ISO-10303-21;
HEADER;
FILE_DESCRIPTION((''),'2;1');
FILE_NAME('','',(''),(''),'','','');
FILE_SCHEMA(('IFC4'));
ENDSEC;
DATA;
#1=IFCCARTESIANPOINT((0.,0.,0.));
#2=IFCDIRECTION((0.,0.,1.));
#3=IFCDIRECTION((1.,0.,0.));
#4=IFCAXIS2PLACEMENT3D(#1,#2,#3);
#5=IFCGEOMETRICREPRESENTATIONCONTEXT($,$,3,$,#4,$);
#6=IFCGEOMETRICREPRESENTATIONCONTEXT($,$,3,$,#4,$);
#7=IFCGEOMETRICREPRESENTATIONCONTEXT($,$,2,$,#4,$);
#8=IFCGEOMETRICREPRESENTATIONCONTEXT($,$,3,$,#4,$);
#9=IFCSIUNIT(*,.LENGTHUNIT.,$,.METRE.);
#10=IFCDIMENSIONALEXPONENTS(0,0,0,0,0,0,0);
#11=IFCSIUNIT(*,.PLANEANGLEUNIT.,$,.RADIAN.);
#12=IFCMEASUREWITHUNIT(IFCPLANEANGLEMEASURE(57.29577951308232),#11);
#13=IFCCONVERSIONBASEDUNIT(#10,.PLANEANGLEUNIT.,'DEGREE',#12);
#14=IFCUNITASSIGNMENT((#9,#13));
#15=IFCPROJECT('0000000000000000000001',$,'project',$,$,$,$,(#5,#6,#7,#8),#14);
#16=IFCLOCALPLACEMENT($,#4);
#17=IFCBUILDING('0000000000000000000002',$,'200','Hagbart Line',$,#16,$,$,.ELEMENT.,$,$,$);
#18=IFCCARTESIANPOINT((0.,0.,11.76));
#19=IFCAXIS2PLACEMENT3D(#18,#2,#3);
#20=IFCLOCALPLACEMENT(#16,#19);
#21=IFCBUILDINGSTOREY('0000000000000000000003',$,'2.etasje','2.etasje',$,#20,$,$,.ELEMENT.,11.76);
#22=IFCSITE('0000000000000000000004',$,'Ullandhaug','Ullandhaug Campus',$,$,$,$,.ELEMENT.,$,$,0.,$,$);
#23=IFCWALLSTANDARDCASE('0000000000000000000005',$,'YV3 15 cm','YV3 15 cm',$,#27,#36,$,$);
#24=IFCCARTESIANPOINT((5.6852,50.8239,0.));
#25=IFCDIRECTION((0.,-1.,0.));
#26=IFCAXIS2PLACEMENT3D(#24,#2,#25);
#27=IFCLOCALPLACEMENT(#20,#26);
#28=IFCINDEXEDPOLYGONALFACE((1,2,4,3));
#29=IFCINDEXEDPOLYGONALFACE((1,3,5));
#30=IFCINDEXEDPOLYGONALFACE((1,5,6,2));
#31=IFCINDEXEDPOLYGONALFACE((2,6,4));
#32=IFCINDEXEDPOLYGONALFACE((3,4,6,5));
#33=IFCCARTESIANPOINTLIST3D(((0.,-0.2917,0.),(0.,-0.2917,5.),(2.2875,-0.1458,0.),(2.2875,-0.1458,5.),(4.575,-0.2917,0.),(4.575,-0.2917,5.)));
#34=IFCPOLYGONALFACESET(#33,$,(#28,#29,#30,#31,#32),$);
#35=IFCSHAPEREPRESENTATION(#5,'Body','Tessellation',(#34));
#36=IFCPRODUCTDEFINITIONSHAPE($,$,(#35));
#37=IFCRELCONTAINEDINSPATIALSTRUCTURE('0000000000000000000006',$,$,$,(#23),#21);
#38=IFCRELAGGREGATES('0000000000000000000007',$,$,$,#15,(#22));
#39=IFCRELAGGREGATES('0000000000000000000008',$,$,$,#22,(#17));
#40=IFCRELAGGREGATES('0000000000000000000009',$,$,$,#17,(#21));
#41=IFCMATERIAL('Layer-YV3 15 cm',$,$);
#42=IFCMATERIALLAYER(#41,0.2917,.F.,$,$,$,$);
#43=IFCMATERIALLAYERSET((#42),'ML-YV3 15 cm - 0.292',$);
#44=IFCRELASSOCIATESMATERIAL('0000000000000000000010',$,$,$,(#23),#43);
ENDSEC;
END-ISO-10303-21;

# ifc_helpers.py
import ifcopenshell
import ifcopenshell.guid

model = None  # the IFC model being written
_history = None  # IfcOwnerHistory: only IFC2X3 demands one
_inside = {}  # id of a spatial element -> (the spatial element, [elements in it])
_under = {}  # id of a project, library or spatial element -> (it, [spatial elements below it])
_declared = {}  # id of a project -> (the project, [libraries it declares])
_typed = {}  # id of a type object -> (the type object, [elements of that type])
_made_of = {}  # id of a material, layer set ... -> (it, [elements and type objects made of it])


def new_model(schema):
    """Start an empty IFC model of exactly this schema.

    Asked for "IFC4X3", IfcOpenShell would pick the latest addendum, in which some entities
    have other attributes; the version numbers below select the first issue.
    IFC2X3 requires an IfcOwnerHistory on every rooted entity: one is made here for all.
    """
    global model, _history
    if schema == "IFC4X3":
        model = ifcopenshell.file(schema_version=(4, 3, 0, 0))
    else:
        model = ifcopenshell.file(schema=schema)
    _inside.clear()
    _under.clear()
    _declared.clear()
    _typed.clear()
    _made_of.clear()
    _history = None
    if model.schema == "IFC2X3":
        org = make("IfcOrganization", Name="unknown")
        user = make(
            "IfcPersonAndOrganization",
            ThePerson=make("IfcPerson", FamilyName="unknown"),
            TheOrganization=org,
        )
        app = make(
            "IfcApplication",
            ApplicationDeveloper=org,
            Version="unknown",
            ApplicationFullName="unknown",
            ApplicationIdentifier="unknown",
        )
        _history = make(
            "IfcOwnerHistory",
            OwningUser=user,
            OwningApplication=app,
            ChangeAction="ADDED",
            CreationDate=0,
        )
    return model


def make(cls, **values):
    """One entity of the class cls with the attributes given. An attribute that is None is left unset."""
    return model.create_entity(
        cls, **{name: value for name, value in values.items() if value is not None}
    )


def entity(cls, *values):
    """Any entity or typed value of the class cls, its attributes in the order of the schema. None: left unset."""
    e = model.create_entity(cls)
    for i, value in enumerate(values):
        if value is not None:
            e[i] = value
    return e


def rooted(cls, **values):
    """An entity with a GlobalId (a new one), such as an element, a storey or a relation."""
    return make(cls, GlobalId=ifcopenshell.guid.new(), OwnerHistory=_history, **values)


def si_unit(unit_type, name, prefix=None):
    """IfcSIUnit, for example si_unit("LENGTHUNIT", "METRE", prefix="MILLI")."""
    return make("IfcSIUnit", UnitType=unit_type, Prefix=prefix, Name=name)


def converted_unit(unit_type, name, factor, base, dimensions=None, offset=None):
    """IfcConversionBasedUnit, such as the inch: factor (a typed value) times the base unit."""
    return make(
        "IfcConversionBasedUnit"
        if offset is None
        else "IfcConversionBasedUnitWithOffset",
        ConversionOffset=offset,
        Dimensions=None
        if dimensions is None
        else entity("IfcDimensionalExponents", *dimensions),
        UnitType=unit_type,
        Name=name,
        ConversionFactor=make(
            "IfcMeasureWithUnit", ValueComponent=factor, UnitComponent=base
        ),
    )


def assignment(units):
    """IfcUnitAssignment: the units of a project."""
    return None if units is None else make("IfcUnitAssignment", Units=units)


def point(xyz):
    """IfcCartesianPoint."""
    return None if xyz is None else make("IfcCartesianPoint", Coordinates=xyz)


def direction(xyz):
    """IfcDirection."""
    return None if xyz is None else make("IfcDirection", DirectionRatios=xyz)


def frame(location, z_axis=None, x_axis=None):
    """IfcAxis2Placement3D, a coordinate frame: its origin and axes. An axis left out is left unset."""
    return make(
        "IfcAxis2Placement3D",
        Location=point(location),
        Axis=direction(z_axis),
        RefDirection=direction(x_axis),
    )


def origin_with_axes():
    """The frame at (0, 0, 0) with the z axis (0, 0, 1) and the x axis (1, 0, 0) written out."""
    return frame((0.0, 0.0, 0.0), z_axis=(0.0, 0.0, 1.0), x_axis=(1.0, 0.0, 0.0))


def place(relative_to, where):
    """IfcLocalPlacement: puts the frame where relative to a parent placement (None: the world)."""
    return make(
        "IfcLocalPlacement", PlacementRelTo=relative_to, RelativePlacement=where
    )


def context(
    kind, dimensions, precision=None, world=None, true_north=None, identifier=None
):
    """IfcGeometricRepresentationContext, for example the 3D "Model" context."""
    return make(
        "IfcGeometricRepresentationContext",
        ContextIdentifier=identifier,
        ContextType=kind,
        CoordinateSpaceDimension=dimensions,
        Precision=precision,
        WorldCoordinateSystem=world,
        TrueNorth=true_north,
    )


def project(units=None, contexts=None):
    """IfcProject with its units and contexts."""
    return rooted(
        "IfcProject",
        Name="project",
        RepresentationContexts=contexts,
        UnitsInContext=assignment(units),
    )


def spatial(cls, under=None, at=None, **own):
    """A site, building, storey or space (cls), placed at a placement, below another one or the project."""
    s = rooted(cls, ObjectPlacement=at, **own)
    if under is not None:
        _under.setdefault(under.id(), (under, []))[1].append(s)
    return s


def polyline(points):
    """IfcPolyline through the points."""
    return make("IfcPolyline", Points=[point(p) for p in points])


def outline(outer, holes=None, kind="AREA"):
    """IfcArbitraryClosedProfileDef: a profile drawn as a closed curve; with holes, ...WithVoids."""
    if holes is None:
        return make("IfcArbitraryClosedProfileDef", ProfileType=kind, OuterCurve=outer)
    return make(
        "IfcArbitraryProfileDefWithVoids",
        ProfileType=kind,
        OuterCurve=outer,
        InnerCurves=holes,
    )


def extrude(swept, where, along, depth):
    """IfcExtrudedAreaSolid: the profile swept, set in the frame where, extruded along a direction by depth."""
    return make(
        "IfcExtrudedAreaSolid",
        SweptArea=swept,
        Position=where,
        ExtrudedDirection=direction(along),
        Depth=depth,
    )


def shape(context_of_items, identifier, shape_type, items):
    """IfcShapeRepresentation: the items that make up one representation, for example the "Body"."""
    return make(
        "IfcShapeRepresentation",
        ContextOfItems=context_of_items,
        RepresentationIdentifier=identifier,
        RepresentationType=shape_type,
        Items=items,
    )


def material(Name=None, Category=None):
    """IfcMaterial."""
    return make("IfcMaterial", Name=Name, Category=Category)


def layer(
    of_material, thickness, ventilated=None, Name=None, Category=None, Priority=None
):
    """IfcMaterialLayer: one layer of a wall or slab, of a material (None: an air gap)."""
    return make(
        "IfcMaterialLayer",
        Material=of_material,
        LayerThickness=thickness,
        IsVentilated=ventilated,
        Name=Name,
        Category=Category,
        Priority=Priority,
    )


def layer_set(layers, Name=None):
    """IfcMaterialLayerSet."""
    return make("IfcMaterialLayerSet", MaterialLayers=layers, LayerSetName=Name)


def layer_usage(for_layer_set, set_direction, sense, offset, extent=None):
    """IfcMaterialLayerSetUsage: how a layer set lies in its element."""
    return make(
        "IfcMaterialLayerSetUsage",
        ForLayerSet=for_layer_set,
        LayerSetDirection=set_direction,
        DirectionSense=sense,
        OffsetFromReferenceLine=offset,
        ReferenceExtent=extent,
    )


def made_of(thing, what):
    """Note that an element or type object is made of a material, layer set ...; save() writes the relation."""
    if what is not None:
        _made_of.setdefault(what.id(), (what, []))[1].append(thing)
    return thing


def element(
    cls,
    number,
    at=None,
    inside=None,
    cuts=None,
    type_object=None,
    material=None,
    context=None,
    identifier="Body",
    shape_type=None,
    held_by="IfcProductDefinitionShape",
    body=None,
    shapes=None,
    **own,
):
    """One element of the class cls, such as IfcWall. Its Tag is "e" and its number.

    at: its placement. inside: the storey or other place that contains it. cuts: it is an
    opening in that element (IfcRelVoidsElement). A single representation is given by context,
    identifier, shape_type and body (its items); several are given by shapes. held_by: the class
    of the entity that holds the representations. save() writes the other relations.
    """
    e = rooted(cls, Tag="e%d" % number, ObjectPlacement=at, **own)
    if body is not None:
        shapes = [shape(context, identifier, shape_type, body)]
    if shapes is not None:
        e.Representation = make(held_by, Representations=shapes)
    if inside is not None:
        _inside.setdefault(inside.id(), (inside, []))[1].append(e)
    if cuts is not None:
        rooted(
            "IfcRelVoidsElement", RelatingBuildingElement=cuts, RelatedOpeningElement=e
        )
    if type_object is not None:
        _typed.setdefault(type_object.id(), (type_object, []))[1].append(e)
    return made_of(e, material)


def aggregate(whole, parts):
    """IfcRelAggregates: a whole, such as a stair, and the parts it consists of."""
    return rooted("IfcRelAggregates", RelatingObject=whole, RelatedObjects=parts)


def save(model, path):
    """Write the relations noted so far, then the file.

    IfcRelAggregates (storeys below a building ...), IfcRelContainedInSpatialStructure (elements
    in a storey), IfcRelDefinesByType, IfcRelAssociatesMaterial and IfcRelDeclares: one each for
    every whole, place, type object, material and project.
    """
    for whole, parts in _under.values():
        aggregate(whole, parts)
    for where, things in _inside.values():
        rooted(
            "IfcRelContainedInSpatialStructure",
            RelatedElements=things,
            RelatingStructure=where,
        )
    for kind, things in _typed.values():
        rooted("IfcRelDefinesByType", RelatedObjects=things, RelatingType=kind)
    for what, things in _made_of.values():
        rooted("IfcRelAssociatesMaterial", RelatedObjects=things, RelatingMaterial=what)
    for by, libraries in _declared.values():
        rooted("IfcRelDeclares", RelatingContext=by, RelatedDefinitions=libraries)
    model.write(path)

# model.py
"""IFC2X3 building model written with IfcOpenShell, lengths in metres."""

from ifc_helpers import new_model, entity, si_unit, converted_unit, frame, origin_with_axes, place, context, project, spatial, polyline, outline, extrude, material, layer, layer_set, layer_usage, element, save


model = new_model("IFC2X3")

# Units and contexts
context_of_model_1 = context(None, 3, world=origin_with_axes())
context_of_model_2 = context(None, 3, world=origin_with_axes())
context_of_model_3 = context(None, 2, world=origin_with_axes())
context_of_model_4 = context(None, 3, world=origin_with_axes())
ifc_project = project(units=[si_unit("LENGTHUNIT", "METRE"), converted_unit("PLANEANGLEUNIT", "DEGREE", entity("IfcPlaneAngleMeasure", 57.29577951308232), si_unit("PLANEANGLEUNIT", "RADIAN"), dimensions=[0, 0, 0, 0, 0, 0, 0])], contexts=[context_of_model_1, context_of_model_2, context_of_model_3, context_of_model_4])

# Site, building, storey
site = spatial("IfcSite", under=ifc_project, Name="Ullandhaug", Description="Ullandhaug Campus", CompositionType="ELEMENT", RefElevation=0.0)
building_placement = place(None, origin_with_axes())
building = spatial("IfcBuilding", under=site, at=building_placement, Name="200", Description="Hagbart Line", CompositionType="ELEMENT")
storey_placement = place(building_placement, frame((0.0, 0.0, 11.76), z_axis=(0.0, 0.0, 1.0), x_axis=(1.0, 0.0, 0.0)))
storey = spatial("IfcBuildingStorey", under=building, at=storey_placement, Name="2.etasje", Description="2.etasje", CompositionType="ELEMENT", Elevation=11.76)

# Wall
ifc_material_1 = material(Name="Layer-YV3 15 cm")
ifc_layer_1 = layer(ifc_material_1, 0.2917, ventilated=False)
ifc_layer_set_1 = layer_set([ifc_layer_1], Name="ML-YV3 15 cm - 0.292")
ifc_layer_usage_1 = layer_usage(ifc_layer_set_1, "AXIS2", "POSITIVE", 0.0)
wall_1_placement = place(storey_placement, frame((5.6852, 50.8239, 0.0), z_axis=(0.0, 0.0, 1.0), x_axis=(0.0, -1.0, 0.0)))
element("IfcWallStandardCase", 1, at=wall_1_placement, inside=storey, material=ifc_layer_usage_1, Name="YV3 15 cm", Description="YV3 15 cm", context=context_of_model_1, shape_type="SweptSolid", body=[
    extrude(outline(polyline([(0.0, 0.0), (4.575, 0.0), (0.0, 0.2917), (4.575, 0.2917), (0.0, 0.0)])), frame((0.0, 0.0, 0.0), z_axis=(0.0, 0.0, -1.0), x_axis=(1.0, 0.0, 0.0)), (0.0, 0.0, -1.0), 5.0),
])

save(model, "model.ifc")
